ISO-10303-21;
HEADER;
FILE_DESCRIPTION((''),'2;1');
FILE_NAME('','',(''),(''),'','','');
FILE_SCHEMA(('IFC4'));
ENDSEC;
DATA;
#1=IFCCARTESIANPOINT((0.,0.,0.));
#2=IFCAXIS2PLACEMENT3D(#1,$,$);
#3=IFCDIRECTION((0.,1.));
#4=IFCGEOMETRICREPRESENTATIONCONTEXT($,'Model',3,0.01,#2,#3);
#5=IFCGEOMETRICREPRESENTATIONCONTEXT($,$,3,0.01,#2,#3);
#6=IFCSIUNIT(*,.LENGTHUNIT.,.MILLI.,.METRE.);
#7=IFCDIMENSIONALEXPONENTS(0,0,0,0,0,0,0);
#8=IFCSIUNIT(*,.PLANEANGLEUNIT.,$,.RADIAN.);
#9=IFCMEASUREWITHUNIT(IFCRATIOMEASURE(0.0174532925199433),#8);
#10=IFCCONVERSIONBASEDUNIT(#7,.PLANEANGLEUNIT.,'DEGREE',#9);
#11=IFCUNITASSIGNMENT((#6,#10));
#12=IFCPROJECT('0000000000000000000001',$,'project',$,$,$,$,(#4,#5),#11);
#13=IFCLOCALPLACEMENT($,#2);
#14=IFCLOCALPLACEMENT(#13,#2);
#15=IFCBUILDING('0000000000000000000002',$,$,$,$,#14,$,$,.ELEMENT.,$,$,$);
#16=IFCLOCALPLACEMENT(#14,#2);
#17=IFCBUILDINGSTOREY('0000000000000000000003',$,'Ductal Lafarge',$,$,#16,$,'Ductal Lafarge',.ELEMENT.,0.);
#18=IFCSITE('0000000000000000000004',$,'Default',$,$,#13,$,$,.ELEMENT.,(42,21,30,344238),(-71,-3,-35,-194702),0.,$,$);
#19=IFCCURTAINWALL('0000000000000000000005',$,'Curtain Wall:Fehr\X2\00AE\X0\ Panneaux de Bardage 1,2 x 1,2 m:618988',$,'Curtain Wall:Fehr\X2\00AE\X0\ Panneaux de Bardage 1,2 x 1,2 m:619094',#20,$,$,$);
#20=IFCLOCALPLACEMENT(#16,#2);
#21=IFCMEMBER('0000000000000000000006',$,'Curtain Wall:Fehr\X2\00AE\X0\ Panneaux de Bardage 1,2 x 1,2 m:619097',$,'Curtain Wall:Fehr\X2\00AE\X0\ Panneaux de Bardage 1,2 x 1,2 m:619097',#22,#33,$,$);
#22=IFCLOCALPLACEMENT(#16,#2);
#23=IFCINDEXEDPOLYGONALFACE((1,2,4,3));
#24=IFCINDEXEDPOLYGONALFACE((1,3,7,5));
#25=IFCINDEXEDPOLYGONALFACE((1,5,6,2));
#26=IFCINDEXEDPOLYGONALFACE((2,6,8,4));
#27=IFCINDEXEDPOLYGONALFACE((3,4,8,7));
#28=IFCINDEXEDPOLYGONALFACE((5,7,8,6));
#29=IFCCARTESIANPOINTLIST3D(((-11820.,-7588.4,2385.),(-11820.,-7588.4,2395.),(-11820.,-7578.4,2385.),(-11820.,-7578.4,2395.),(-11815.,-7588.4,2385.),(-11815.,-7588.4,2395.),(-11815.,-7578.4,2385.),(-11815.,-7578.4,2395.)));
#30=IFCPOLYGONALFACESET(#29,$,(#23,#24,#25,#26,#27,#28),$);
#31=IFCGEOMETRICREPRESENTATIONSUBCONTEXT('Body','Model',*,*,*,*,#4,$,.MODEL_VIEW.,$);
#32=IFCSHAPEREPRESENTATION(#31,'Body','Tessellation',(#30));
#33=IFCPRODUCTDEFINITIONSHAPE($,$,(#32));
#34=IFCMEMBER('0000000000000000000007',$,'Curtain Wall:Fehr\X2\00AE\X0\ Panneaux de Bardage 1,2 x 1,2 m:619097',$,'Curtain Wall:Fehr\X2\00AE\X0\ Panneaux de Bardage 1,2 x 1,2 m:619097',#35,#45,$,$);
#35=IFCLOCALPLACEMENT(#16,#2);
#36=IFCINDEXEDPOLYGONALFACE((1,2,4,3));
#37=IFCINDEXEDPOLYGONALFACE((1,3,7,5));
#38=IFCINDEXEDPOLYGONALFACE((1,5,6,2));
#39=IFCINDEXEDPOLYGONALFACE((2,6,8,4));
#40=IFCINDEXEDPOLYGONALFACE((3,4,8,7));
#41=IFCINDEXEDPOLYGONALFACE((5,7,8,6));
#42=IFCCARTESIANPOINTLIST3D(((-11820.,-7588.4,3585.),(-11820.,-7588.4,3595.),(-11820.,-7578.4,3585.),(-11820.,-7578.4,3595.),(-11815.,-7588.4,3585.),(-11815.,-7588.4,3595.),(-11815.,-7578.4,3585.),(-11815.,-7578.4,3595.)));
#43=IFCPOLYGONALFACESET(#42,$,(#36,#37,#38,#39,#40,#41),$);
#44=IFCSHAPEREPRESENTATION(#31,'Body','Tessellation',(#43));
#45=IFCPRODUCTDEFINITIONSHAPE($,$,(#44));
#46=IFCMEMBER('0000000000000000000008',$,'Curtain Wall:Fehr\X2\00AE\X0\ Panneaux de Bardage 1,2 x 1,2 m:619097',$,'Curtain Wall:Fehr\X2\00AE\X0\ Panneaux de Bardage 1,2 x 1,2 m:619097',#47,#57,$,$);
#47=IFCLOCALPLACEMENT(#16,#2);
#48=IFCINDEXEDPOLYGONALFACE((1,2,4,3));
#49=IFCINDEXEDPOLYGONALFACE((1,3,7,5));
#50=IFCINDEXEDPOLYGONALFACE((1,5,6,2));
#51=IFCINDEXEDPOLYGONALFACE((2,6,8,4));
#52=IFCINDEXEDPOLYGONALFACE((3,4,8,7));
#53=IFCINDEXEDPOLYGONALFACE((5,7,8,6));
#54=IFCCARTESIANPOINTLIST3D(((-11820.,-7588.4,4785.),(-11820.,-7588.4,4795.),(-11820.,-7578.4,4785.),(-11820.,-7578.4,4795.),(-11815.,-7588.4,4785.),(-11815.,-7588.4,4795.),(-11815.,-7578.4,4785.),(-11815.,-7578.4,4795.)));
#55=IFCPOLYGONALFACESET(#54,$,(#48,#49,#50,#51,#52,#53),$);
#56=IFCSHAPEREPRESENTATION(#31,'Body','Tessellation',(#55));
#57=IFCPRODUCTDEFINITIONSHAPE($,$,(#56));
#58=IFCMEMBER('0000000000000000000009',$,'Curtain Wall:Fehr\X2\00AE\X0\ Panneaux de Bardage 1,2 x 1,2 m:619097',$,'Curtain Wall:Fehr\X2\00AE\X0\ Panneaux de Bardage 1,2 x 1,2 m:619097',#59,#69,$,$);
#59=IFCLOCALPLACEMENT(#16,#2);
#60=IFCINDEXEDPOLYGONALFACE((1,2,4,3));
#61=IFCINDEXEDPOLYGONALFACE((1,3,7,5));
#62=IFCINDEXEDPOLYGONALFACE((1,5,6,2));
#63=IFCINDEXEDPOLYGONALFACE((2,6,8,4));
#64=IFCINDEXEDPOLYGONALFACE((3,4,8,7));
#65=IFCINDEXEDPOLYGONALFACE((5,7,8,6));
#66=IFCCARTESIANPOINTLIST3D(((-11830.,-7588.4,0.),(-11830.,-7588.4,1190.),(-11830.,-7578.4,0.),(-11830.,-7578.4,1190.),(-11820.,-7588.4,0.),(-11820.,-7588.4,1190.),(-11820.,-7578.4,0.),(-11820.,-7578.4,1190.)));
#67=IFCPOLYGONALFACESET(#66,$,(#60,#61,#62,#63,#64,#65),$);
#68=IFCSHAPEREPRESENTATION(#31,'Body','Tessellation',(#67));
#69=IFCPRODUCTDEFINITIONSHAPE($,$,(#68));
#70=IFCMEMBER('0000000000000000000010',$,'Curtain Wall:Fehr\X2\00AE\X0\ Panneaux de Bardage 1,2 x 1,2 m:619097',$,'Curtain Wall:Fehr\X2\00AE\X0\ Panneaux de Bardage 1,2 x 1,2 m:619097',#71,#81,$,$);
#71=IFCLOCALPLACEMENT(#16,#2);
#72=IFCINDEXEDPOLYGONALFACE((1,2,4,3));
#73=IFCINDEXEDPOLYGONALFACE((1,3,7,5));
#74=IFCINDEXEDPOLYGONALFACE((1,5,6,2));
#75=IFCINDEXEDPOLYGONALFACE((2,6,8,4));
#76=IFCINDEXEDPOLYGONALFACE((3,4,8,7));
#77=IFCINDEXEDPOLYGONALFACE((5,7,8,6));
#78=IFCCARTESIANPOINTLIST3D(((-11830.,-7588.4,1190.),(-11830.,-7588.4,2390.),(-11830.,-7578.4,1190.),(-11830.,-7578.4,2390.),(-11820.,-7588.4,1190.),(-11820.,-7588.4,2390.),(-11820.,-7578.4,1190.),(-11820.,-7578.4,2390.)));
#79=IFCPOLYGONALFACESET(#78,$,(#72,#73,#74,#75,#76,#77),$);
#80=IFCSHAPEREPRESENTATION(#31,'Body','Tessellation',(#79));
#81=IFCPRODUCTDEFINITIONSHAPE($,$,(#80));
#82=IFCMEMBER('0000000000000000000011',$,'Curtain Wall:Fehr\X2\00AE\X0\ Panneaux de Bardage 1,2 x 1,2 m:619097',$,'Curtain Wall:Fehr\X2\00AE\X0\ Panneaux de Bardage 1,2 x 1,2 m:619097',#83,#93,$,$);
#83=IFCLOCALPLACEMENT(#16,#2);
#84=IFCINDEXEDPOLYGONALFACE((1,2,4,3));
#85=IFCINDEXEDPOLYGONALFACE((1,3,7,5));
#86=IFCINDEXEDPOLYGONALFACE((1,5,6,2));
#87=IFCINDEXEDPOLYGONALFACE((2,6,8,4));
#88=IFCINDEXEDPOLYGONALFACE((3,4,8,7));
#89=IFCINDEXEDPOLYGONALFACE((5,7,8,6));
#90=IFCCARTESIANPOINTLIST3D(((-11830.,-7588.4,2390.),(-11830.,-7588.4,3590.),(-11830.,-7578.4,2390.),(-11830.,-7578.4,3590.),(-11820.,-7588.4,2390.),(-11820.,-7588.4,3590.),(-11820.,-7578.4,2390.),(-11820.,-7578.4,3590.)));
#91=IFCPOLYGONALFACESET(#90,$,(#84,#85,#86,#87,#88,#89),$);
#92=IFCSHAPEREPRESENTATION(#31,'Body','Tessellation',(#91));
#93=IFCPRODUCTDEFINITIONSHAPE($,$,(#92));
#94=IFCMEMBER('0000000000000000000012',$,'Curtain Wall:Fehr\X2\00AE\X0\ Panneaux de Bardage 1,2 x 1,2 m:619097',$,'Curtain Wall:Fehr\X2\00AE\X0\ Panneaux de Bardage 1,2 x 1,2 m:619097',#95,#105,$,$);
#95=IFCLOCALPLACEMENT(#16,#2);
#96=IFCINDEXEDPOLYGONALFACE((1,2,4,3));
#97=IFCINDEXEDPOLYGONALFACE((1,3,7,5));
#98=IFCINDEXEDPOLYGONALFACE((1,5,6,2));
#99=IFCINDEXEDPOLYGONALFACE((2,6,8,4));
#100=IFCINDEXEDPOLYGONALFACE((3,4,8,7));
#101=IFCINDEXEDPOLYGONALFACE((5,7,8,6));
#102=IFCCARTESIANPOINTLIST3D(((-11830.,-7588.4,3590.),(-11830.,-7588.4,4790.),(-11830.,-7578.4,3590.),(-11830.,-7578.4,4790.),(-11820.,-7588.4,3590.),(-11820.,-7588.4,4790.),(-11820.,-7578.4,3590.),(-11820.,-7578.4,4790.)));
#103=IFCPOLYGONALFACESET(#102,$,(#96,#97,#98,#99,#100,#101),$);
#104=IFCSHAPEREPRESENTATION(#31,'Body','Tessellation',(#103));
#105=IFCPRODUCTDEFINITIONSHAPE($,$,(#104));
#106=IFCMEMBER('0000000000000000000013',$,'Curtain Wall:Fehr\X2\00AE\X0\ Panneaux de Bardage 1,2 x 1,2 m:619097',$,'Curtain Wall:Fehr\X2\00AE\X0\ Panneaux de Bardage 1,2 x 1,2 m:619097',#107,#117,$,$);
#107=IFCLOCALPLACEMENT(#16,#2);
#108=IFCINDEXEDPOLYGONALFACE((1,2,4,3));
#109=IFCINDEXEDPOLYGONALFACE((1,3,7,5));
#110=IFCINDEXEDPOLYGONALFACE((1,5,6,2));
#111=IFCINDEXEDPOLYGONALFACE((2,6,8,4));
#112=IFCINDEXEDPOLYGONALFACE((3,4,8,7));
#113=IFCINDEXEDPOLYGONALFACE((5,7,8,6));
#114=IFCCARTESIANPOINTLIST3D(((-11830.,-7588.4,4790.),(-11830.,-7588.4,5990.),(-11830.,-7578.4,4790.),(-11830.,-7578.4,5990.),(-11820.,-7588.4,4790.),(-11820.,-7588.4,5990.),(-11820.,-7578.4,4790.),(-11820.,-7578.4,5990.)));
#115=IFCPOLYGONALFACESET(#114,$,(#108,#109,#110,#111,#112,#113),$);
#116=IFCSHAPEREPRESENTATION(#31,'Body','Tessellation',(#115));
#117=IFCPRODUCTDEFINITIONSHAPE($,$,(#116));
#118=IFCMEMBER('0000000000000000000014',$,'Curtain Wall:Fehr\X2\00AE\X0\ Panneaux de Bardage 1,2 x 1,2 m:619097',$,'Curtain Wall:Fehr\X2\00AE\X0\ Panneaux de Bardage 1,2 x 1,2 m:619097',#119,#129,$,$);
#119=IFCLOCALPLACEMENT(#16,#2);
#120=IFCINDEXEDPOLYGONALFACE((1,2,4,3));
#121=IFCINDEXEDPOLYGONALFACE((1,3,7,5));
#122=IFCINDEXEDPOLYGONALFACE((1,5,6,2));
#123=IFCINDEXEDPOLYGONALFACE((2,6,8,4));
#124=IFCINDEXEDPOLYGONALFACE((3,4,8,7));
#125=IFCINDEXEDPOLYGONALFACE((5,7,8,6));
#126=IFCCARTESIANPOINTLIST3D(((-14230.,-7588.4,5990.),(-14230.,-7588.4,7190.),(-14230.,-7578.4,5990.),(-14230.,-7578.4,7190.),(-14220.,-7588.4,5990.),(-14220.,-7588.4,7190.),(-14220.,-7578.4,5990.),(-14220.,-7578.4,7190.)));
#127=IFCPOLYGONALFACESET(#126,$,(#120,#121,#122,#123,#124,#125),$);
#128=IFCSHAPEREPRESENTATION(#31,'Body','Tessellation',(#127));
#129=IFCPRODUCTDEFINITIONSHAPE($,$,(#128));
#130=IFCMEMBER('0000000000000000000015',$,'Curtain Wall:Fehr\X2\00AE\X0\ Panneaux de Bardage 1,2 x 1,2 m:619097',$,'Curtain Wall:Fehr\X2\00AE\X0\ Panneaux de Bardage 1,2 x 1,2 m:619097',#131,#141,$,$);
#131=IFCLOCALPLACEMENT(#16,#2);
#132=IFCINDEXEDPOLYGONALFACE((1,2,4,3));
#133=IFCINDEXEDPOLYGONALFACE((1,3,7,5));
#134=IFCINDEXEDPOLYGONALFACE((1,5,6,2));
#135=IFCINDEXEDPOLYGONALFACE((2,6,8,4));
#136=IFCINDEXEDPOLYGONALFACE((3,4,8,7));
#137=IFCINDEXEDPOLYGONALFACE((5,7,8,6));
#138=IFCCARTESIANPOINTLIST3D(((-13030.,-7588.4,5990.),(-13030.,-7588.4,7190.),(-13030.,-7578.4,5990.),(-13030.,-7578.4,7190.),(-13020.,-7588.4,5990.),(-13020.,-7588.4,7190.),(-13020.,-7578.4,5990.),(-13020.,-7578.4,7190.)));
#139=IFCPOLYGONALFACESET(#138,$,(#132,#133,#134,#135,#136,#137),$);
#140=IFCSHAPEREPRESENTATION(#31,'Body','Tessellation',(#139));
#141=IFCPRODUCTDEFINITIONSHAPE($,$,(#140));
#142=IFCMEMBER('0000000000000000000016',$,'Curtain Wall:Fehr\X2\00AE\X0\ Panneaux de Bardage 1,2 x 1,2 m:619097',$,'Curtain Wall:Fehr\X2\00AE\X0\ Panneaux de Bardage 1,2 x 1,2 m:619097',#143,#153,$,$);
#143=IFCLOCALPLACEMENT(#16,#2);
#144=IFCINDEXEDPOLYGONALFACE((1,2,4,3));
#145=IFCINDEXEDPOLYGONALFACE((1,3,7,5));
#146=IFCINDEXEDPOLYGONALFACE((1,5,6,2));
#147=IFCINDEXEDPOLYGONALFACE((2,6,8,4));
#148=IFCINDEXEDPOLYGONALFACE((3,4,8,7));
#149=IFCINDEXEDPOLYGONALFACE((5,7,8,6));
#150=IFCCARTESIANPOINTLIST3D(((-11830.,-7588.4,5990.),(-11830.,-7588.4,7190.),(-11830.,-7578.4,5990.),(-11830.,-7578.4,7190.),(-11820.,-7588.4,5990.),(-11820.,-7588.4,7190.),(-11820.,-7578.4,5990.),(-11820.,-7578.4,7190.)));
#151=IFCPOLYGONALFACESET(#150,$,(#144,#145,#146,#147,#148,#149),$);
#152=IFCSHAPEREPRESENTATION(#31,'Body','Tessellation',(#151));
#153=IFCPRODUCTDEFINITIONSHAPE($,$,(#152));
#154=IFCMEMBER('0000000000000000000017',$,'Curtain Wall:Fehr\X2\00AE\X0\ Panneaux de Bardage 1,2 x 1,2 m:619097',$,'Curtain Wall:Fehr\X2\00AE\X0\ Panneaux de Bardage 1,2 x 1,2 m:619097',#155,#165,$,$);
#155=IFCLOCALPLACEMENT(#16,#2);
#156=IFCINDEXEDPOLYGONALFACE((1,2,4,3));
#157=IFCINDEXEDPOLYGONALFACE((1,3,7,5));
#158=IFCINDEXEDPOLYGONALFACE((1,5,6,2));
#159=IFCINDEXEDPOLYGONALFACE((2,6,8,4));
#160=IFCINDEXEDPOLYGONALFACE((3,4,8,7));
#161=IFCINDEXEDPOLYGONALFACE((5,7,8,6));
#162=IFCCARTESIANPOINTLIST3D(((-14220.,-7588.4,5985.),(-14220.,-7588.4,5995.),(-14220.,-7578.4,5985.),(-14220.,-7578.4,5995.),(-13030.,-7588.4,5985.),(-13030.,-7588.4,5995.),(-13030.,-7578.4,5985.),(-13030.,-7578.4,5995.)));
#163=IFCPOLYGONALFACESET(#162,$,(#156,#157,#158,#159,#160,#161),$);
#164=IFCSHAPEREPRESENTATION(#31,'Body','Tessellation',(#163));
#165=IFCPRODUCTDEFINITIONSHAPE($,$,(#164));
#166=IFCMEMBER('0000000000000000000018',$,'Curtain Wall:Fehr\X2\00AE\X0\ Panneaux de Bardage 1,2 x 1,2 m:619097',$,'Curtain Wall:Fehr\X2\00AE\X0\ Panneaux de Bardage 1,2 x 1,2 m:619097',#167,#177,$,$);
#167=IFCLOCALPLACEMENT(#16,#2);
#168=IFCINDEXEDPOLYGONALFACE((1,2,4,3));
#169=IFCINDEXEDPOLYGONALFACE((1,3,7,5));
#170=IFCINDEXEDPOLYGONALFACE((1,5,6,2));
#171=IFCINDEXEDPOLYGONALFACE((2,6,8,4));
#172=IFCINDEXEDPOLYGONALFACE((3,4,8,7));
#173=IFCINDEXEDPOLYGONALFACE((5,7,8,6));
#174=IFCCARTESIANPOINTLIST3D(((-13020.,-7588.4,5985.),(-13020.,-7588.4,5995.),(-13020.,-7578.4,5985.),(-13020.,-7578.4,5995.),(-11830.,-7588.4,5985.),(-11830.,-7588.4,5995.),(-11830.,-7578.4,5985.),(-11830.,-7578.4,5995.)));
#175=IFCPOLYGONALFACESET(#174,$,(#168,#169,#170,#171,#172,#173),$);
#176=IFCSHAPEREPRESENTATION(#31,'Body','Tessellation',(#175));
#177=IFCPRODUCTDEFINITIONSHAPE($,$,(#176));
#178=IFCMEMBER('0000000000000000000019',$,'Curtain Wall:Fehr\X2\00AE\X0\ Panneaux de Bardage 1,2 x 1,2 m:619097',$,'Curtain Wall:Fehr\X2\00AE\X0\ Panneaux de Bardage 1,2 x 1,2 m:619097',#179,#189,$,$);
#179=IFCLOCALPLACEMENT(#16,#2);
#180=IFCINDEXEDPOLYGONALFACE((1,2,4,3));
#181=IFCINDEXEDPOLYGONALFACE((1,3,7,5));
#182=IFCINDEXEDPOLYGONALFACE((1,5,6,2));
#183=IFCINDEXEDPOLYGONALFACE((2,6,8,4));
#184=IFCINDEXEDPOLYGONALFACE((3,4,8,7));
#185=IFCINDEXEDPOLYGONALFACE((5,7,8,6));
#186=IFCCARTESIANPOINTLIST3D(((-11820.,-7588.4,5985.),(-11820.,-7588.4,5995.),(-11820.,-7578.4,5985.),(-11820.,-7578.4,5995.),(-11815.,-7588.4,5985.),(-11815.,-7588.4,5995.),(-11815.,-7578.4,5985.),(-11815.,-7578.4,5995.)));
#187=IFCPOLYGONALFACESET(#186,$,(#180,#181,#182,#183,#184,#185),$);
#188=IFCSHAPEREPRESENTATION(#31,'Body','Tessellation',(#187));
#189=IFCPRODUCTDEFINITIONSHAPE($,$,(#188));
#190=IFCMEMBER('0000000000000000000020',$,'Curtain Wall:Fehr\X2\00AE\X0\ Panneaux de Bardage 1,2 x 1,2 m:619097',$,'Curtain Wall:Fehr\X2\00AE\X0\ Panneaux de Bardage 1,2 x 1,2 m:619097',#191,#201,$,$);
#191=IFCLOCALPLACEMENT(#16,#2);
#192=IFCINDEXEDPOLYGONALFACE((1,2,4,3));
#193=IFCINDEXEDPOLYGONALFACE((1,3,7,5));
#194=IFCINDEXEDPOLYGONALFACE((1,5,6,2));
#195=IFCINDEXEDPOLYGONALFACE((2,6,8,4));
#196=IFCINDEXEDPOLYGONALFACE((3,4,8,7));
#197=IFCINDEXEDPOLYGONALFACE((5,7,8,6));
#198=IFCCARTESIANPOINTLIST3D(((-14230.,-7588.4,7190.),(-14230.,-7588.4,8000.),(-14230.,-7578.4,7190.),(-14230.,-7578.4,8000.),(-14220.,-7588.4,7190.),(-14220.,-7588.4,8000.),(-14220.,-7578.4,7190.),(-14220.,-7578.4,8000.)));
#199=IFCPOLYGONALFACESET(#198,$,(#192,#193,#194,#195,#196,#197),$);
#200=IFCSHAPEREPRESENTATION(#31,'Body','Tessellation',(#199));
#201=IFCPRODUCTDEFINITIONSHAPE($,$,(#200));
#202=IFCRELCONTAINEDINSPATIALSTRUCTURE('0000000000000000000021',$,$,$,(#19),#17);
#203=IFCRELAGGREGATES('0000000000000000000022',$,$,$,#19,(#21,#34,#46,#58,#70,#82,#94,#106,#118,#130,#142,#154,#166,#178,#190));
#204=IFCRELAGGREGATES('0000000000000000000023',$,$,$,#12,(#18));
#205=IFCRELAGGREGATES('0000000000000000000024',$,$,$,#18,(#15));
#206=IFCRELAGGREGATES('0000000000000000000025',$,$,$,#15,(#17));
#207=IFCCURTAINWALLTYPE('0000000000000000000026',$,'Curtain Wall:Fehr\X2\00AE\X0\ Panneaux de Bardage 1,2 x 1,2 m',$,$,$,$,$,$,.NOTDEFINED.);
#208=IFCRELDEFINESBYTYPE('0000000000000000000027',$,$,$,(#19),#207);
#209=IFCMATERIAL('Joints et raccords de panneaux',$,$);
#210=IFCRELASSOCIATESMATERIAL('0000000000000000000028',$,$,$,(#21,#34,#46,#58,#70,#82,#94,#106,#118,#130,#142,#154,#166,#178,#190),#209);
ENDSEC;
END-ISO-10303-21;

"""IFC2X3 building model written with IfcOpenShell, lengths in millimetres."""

from ifc_helpers import new_model, entity, si_unit, converted_unit, direction, frame, frame_2d, origin, origin_2d_with_axis, place, context, subcontext, project, spatial, rectangle, extrude, material, type_object, element, aggregate, save


model = new_model("IFC2X3")

# Units and contexts
model_context = context("Model", 3, precision=0.01, world=origin(), true_north=direction((0.0, 1.0)))
context_of_model = context(None, 3, precision=0.01, world=origin(), true_north=direction((0.0, 1.0)))
body_context = subcontext(model_context, "Body", "Model", "MODEL_VIEW")
ifc_project = project(units=[si_unit("LENGTHUNIT", "METRE", prefix="MILLI"), converted_unit("PLANEANGLEUNIT", "DEGREE", entity("IfcRatioMeasure", 0.0174532925199433), si_unit("PLANEANGLEUNIT", "RADIAN"), dimensions=[0, 0, 0, 0, 0, 0, 0])], contexts=[model_context, context_of_model])

# Site, building, storey
site_placement = place(None, origin())
site = spatial("IfcSite", under=ifc_project, at=site_placement, Name="Default", CompositionType="ELEMENT", RefLatitude=(42, 21, 30, 344238), RefLongitude=(-71, -3, -35, -194702), RefElevation=0.0)
building_placement = place(site_placement, origin())
building = spatial("IfcBuilding", under=site, at=building_placement, CompositionType="ELEMENT")
storey_placement = place(building_placement, origin())
storey = spatial("IfcBuildingStorey", under=building, at=storey_placement, Name="Ductal Lafarge", LongName="Ductal Lafarge", CompositionType="ELEMENT", Elevation=0.0)

# Curtain wall, members
curtain_wall_type = type_object("IfcCurtainWallType", Name="Curtain Wall:Fehr® Panneaux de Bardage 1,2 x 1,2 m", PredefinedType="NOTDEFINED")
curtain_wall_placement = place(storey_placement, origin())
curtain_wall = element("IfcCurtainWall", 1, at=curtain_wall_placement, inside=storey, type_object=curtain_wall_type, Name="Curtain Wall:Fehr® Panneaux de Bardage 1,2 x 1,2 m:618988", ObjectType="Curtain Wall:Fehr® Panneaux de Bardage 1,2 x 1,2 m:619094")
ifc_material = material(Name="Joints et raccords de panneaux")
member_1_placement = place(curtain_wall_placement, frame((-11820.0, -7588.4, 2385.0)))
member_1 = element("IfcMember", 2, at=member_1_placement, material=ifc_material, Name="Curtain Wall:Fehr® Panneaux de Bardage 1,2 x 1,2 m:619097", ObjectType="Curtain Wall:Fehr® Panneaux de Bardage 1,2 x 1,2 m:619097", context=body_context, shape_type="SweptSolid", body=[
    extrude(rectangle(XDim=5.0, YDim=10.0, at=origin_2d_with_axis()), frame((2.5, 5.0, 0.0), z_axis=(0.0, 0.0, 1.0), x_axis=(-1.0, 0.0, 0.0)), (0.0, 0.0, 1.0), 10.0),
])
member_2_placement = place(curtain_wall_placement, frame((-11820.0, -7588.4, 3585.0)))
member_2 = element("IfcMember", 3, at=member_2_placement, material=ifc_material, Name="Curtain Wall:Fehr® Panneaux de Bardage 1,2 x 1,2 m:619097", ObjectType="Curtain Wall:Fehr® Panneaux de Bardage 1,2 x 1,2 m:619097", context=body_context, shape_type="SweptSolid", body=[
    extrude(rectangle(XDim=5.0, YDim=10.0, at=origin_2d_with_axis()), frame((2.5, 5.0, 0.0), z_axis=(0.0, 0.0, 1.0), x_axis=(-1.0, 0.0, 0.0)), (0.0, 0.0, 1.0), 10.0),
])
member_3_placement = place(curtain_wall_placement, frame((-11820.0, -7588.4, 4785.0)))
member_3 = element("IfcMember", 4, at=member_3_placement, material=ifc_material, Name="Curtain Wall:Fehr® Panneaux de Bardage 1,2 x 1,2 m:619097", ObjectType="Curtain Wall:Fehr® Panneaux de Bardage 1,2 x 1,2 m:619097", context=body_context, shape_type="SweptSolid", body=[
    extrude(rectangle(XDim=5.0, YDim=10.0, at=origin_2d_with_axis()), frame((2.5, 5.0, 0.0), z_axis=(0.0, 0.0, 1.0), x_axis=(-1.0, 0.0, 0.0)), (0.0, 0.0, 1.0), 10.0),
])
member_4_placement = place(curtain_wall_placement, frame((-11830.0, -7588.4, 0.0)))
member_4 = element("IfcMember", 5, at=member_4_placement, material=ifc_material, Name="Curtain Wall:Fehr® Panneaux de Bardage 1,2 x 1,2 m:619097", ObjectType="Curtain Wall:Fehr® Panneaux de Bardage 1,2 x 1,2 m:619097", context=body_context, shape_type="SweptSolid", body=[
    extrude(rectangle(XDim=10.0, YDim=10.0, at=origin_2d_with_axis()), frame((5.0, 5.0, 0.0), z_axis=(0.0, 0.0, 1.0), x_axis=(0.0, 1.0, 0.0)), (0.0, 0.0, 1.0), 1190.0),
])
member_5_placement = place(curtain_wall_placement, frame((-11830.0, -7588.4, 1190.0)))
member_5 = element("IfcMember", 6, at=member_5_placement, material=ifc_material, Name="Curtain Wall:Fehr® Panneaux de Bardage 1,2 x 1,2 m:619097", ObjectType="Curtain Wall:Fehr® Panneaux de Bardage 1,2 x 1,2 m:619097", context=body_context, shape_type="SweptSolid", body=[
    extrude(rectangle(XDim=10.0, YDim=10.0, at=origin_2d_with_axis()), frame((5.0, 5.0, 0.0), z_axis=(0.0, 0.0, 1.0), x_axis=(0.0, 1.0, 0.0)), (0.0, 0.0, 1.0), 1200.0),
])
member_6_placement = place(curtain_wall_placement, frame((-11830.0, -7588.4, 2390.0)))
member_6 = element("IfcMember", 7, at=member_6_placement, material=ifc_material, Name="Curtain Wall:Fehr® Panneaux de Bardage 1,2 x 1,2 m:619097", ObjectType="Curtain Wall:Fehr® Panneaux de Bardage 1,2 x 1,2 m:619097", context=body_context, shape_type="SweptSolid", body=[
    extrude(rectangle(XDim=10.0, YDim=10.0, at=origin_2d_with_axis()), frame((5.0, 5.0, 0.0), z_axis=(0.0, 0.0, 1.0), x_axis=(0.0, 1.0, 0.0)), (0.0, 0.0, 1.0), 1200.0),
])
member_7_placement = place(curtain_wall_placement, frame((-11830.0, -7588.4, 3590.0)))
member_7 = element("IfcMember", 8, at=member_7_placement, material=ifc_material, Name="Curtain Wall:Fehr® Panneaux de Bardage 1,2 x 1,2 m:619097", ObjectType="Curtain Wall:Fehr® Panneaux de Bardage 1,2 x 1,2 m:619097", context=body_context, shape_type="SweptSolid", body=[
    extrude(rectangle(XDim=10.0, YDim=10.0, at=origin_2d_with_axis()), frame((5.0, 5.0, 0.0), z_axis=(0.0, 0.0, 1.0), x_axis=(0.0, 1.0, 0.0)), (0.0, 0.0, 1.0), 1200.0),
])
member_8_placement = place(curtain_wall_placement, frame((-11830.0, -7588.4, 4790.0)))
member_8 = element("IfcMember", 9, at=member_8_placement, material=ifc_material, Name="Curtain Wall:Fehr® Panneaux de Bardage 1,2 x 1,2 m:619097", ObjectType="Curtain Wall:Fehr® Panneaux de Bardage 1,2 x 1,2 m:619097", context=body_context, shape_type="SweptSolid", body=[
    extrude(rectangle(XDim=10.0, YDim=10.0, at=origin_2d_with_axis()), frame((5.0, 5.0, 0.0), z_axis=(0.0, 0.0, 1.0), x_axis=(0.0, 1.0, 0.0)), (0.0, 0.0, 1.0), 1200.0),
])
member_9_placement = place(curtain_wall_placement, frame((-14230.0, -7588.4, 5990.0)))
member_9 = element("IfcMember", 10, at=member_9_placement, material=ifc_material, Name="Curtain Wall:Fehr® Panneaux de Bardage 1,2 x 1,2 m:619097", ObjectType="Curtain Wall:Fehr® Panneaux de Bardage 1,2 x 1,2 m:619097", context=body_context, shape_type="SweptSolid", body=[
    extrude(rectangle(XDim=10.0, YDim=10.0, at=origin_2d_with_axis()), frame((5.0, 5.0, 0.0), z_axis=(0.0, 0.0, 1.0), x_axis=(0.0, 1.0, 0.0)), (0.0, 0.0, 1.0), 1200.0),
])
member_10_placement = place(curtain_wall_placement, frame((-13030.0, -7588.4, 5990.0)))
member_10 = element("IfcMember", 11, at=member_10_placement, material=ifc_material, Name="Curtain Wall:Fehr® Panneaux de Bardage 1,2 x 1,2 m:619097", ObjectType="Curtain Wall:Fehr® Panneaux de Bardage 1,2 x 1,2 m:619097", context=body_context, shape_type="SweptSolid", body=[
    extrude(rectangle(XDim=10.0, YDim=10.0, at=origin_2d_with_axis()), frame((5.0, 5.0, 0.0), z_axis=(0.0, 0.0, 1.0), x_axis=(0.0, 1.0, 0.0)), (0.0, 0.0, 1.0), 1200.0),
])
member_11_placement = place(curtain_wall_placement, frame((-11830.0, -7588.4, 5990.0)))
member_11 = element("IfcMember", 12, at=member_11_placement, material=ifc_material, Name="Curtain Wall:Fehr® Panneaux de Bardage 1,2 x 1,2 m:619097", ObjectType="Curtain Wall:Fehr® Panneaux de Bardage 1,2 x 1,2 m:619097", context=body_context, shape_type="SweptSolid", body=[
    extrude(rectangle(XDim=10.0, YDim=10.0, at=origin_2d_with_axis()), frame((5.0, 5.0, 0.0), z_axis=(0.0, 0.0, 1.0), x_axis=(0.0, 1.0, 0.0)), (0.0, 0.0, 1.0), 1200.0),
])
member_12_placement = place(curtain_wall_placement, frame((-14220.0, -7588.4, 5985.0)))
member_12 = element("IfcMember", 13, at=member_12_placement, material=ifc_material, Name="Curtain Wall:Fehr® Panneaux de Bardage 1,2 x 1,2 m:619097", ObjectType="Curtain Wall:Fehr® Panneaux de Bardage 1,2 x 1,2 m:619097", context=body_context, shape_type="SweptSolid", body=[
    extrude(rectangle(XDim=1190.0, YDim=10.0, at=frame_2d((0.0, 0.0), x_axis=(1.0, 0.0))), frame((595.0, 5.0, 0.0), z_axis=(0.0, 0.0, 1.0), x_axis=(-1.0, 0.0, 0.0)), (0.0, 0.0, 1.0), 10.0),
])
member_13_placement = place(curtain_wall_placement, frame((-13020.0, -7588.4, 5985.0)))
member_13 = element("IfcMember", 14, at=member_13_placement, material=ifc_material, Name="Curtain Wall:Fehr® Panneaux de Bardage 1,2 x 1,2 m:619097", ObjectType="Curtain Wall:Fehr® Panneaux de Bardage 1,2 x 1,2 m:619097", context=body_context, shape_type="SweptSolid", body=[
    extrude(rectangle(XDim=1190.0, YDim=10.0, at=frame_2d((0.0, 0.0), x_axis=(1.0, 0.0))), frame((595.0, 5.0, 0.0), z_axis=(0.0, 0.0, 1.0), x_axis=(-1.0, 0.0, 0.0)), (0.0, 0.0, 1.0), 10.0),
])
member_14_placement = place(curtain_wall_placement, frame((-11820.0, -7588.4, 5985.0)))
member_14 = element("IfcMember", 15, at=member_14_placement, material=ifc_material, Name="Curtain Wall:Fehr® Panneaux de Bardage 1,2 x 1,2 m:619097", ObjectType="Curtain Wall:Fehr® Panneaux de Bardage 1,2 x 1,2 m:619097", context=body_context, shape_type="SweptSolid", body=[
    extrude(rectangle(XDim=5.0, YDim=10.0, at=origin_2d_with_axis()), frame((2.5, 5.0, 0.0), z_axis=(0.0, 0.0, 1.0), x_axis=(-1.0, 0.0, 0.0)), (0.0, 0.0, 1.0), 10.0),
])
member_15_placement = place(curtain_wall_placement, frame((-14230.0, -7588.4, 7190.0)))
member_15 = element("IfcMember", 16, at=member_15_placement, material=ifc_material, Name="Curtain Wall:Fehr® Panneaux de Bardage 1,2 x 1,2 m:619097", ObjectType="Curtain Wall:Fehr® Panneaux de Bardage 1,2 x 1,2 m:619097", context=body_context, shape_type="SweptSolid", body=[
    extrude(rectangle(XDim=10.0, YDim=10.0, at=frame_2d((0.0, 0.0), x_axis=(1.0, 0.0))), frame((5.0, 5.0, 0.0), z_axis=(0.0, 0.0, 1.0), x_axis=(0.0, 1.0, 0.0)), (0.0, 0.0, 1.0), 810.0),
])
aggregate(curtain_wall, [member_1, member_2, member_3, member_4, member_5, member_6, member_7, member_8, member_9, member_10, member_11, member_12, member_13, member_14, member_15])

save(model, "model.ifc")
